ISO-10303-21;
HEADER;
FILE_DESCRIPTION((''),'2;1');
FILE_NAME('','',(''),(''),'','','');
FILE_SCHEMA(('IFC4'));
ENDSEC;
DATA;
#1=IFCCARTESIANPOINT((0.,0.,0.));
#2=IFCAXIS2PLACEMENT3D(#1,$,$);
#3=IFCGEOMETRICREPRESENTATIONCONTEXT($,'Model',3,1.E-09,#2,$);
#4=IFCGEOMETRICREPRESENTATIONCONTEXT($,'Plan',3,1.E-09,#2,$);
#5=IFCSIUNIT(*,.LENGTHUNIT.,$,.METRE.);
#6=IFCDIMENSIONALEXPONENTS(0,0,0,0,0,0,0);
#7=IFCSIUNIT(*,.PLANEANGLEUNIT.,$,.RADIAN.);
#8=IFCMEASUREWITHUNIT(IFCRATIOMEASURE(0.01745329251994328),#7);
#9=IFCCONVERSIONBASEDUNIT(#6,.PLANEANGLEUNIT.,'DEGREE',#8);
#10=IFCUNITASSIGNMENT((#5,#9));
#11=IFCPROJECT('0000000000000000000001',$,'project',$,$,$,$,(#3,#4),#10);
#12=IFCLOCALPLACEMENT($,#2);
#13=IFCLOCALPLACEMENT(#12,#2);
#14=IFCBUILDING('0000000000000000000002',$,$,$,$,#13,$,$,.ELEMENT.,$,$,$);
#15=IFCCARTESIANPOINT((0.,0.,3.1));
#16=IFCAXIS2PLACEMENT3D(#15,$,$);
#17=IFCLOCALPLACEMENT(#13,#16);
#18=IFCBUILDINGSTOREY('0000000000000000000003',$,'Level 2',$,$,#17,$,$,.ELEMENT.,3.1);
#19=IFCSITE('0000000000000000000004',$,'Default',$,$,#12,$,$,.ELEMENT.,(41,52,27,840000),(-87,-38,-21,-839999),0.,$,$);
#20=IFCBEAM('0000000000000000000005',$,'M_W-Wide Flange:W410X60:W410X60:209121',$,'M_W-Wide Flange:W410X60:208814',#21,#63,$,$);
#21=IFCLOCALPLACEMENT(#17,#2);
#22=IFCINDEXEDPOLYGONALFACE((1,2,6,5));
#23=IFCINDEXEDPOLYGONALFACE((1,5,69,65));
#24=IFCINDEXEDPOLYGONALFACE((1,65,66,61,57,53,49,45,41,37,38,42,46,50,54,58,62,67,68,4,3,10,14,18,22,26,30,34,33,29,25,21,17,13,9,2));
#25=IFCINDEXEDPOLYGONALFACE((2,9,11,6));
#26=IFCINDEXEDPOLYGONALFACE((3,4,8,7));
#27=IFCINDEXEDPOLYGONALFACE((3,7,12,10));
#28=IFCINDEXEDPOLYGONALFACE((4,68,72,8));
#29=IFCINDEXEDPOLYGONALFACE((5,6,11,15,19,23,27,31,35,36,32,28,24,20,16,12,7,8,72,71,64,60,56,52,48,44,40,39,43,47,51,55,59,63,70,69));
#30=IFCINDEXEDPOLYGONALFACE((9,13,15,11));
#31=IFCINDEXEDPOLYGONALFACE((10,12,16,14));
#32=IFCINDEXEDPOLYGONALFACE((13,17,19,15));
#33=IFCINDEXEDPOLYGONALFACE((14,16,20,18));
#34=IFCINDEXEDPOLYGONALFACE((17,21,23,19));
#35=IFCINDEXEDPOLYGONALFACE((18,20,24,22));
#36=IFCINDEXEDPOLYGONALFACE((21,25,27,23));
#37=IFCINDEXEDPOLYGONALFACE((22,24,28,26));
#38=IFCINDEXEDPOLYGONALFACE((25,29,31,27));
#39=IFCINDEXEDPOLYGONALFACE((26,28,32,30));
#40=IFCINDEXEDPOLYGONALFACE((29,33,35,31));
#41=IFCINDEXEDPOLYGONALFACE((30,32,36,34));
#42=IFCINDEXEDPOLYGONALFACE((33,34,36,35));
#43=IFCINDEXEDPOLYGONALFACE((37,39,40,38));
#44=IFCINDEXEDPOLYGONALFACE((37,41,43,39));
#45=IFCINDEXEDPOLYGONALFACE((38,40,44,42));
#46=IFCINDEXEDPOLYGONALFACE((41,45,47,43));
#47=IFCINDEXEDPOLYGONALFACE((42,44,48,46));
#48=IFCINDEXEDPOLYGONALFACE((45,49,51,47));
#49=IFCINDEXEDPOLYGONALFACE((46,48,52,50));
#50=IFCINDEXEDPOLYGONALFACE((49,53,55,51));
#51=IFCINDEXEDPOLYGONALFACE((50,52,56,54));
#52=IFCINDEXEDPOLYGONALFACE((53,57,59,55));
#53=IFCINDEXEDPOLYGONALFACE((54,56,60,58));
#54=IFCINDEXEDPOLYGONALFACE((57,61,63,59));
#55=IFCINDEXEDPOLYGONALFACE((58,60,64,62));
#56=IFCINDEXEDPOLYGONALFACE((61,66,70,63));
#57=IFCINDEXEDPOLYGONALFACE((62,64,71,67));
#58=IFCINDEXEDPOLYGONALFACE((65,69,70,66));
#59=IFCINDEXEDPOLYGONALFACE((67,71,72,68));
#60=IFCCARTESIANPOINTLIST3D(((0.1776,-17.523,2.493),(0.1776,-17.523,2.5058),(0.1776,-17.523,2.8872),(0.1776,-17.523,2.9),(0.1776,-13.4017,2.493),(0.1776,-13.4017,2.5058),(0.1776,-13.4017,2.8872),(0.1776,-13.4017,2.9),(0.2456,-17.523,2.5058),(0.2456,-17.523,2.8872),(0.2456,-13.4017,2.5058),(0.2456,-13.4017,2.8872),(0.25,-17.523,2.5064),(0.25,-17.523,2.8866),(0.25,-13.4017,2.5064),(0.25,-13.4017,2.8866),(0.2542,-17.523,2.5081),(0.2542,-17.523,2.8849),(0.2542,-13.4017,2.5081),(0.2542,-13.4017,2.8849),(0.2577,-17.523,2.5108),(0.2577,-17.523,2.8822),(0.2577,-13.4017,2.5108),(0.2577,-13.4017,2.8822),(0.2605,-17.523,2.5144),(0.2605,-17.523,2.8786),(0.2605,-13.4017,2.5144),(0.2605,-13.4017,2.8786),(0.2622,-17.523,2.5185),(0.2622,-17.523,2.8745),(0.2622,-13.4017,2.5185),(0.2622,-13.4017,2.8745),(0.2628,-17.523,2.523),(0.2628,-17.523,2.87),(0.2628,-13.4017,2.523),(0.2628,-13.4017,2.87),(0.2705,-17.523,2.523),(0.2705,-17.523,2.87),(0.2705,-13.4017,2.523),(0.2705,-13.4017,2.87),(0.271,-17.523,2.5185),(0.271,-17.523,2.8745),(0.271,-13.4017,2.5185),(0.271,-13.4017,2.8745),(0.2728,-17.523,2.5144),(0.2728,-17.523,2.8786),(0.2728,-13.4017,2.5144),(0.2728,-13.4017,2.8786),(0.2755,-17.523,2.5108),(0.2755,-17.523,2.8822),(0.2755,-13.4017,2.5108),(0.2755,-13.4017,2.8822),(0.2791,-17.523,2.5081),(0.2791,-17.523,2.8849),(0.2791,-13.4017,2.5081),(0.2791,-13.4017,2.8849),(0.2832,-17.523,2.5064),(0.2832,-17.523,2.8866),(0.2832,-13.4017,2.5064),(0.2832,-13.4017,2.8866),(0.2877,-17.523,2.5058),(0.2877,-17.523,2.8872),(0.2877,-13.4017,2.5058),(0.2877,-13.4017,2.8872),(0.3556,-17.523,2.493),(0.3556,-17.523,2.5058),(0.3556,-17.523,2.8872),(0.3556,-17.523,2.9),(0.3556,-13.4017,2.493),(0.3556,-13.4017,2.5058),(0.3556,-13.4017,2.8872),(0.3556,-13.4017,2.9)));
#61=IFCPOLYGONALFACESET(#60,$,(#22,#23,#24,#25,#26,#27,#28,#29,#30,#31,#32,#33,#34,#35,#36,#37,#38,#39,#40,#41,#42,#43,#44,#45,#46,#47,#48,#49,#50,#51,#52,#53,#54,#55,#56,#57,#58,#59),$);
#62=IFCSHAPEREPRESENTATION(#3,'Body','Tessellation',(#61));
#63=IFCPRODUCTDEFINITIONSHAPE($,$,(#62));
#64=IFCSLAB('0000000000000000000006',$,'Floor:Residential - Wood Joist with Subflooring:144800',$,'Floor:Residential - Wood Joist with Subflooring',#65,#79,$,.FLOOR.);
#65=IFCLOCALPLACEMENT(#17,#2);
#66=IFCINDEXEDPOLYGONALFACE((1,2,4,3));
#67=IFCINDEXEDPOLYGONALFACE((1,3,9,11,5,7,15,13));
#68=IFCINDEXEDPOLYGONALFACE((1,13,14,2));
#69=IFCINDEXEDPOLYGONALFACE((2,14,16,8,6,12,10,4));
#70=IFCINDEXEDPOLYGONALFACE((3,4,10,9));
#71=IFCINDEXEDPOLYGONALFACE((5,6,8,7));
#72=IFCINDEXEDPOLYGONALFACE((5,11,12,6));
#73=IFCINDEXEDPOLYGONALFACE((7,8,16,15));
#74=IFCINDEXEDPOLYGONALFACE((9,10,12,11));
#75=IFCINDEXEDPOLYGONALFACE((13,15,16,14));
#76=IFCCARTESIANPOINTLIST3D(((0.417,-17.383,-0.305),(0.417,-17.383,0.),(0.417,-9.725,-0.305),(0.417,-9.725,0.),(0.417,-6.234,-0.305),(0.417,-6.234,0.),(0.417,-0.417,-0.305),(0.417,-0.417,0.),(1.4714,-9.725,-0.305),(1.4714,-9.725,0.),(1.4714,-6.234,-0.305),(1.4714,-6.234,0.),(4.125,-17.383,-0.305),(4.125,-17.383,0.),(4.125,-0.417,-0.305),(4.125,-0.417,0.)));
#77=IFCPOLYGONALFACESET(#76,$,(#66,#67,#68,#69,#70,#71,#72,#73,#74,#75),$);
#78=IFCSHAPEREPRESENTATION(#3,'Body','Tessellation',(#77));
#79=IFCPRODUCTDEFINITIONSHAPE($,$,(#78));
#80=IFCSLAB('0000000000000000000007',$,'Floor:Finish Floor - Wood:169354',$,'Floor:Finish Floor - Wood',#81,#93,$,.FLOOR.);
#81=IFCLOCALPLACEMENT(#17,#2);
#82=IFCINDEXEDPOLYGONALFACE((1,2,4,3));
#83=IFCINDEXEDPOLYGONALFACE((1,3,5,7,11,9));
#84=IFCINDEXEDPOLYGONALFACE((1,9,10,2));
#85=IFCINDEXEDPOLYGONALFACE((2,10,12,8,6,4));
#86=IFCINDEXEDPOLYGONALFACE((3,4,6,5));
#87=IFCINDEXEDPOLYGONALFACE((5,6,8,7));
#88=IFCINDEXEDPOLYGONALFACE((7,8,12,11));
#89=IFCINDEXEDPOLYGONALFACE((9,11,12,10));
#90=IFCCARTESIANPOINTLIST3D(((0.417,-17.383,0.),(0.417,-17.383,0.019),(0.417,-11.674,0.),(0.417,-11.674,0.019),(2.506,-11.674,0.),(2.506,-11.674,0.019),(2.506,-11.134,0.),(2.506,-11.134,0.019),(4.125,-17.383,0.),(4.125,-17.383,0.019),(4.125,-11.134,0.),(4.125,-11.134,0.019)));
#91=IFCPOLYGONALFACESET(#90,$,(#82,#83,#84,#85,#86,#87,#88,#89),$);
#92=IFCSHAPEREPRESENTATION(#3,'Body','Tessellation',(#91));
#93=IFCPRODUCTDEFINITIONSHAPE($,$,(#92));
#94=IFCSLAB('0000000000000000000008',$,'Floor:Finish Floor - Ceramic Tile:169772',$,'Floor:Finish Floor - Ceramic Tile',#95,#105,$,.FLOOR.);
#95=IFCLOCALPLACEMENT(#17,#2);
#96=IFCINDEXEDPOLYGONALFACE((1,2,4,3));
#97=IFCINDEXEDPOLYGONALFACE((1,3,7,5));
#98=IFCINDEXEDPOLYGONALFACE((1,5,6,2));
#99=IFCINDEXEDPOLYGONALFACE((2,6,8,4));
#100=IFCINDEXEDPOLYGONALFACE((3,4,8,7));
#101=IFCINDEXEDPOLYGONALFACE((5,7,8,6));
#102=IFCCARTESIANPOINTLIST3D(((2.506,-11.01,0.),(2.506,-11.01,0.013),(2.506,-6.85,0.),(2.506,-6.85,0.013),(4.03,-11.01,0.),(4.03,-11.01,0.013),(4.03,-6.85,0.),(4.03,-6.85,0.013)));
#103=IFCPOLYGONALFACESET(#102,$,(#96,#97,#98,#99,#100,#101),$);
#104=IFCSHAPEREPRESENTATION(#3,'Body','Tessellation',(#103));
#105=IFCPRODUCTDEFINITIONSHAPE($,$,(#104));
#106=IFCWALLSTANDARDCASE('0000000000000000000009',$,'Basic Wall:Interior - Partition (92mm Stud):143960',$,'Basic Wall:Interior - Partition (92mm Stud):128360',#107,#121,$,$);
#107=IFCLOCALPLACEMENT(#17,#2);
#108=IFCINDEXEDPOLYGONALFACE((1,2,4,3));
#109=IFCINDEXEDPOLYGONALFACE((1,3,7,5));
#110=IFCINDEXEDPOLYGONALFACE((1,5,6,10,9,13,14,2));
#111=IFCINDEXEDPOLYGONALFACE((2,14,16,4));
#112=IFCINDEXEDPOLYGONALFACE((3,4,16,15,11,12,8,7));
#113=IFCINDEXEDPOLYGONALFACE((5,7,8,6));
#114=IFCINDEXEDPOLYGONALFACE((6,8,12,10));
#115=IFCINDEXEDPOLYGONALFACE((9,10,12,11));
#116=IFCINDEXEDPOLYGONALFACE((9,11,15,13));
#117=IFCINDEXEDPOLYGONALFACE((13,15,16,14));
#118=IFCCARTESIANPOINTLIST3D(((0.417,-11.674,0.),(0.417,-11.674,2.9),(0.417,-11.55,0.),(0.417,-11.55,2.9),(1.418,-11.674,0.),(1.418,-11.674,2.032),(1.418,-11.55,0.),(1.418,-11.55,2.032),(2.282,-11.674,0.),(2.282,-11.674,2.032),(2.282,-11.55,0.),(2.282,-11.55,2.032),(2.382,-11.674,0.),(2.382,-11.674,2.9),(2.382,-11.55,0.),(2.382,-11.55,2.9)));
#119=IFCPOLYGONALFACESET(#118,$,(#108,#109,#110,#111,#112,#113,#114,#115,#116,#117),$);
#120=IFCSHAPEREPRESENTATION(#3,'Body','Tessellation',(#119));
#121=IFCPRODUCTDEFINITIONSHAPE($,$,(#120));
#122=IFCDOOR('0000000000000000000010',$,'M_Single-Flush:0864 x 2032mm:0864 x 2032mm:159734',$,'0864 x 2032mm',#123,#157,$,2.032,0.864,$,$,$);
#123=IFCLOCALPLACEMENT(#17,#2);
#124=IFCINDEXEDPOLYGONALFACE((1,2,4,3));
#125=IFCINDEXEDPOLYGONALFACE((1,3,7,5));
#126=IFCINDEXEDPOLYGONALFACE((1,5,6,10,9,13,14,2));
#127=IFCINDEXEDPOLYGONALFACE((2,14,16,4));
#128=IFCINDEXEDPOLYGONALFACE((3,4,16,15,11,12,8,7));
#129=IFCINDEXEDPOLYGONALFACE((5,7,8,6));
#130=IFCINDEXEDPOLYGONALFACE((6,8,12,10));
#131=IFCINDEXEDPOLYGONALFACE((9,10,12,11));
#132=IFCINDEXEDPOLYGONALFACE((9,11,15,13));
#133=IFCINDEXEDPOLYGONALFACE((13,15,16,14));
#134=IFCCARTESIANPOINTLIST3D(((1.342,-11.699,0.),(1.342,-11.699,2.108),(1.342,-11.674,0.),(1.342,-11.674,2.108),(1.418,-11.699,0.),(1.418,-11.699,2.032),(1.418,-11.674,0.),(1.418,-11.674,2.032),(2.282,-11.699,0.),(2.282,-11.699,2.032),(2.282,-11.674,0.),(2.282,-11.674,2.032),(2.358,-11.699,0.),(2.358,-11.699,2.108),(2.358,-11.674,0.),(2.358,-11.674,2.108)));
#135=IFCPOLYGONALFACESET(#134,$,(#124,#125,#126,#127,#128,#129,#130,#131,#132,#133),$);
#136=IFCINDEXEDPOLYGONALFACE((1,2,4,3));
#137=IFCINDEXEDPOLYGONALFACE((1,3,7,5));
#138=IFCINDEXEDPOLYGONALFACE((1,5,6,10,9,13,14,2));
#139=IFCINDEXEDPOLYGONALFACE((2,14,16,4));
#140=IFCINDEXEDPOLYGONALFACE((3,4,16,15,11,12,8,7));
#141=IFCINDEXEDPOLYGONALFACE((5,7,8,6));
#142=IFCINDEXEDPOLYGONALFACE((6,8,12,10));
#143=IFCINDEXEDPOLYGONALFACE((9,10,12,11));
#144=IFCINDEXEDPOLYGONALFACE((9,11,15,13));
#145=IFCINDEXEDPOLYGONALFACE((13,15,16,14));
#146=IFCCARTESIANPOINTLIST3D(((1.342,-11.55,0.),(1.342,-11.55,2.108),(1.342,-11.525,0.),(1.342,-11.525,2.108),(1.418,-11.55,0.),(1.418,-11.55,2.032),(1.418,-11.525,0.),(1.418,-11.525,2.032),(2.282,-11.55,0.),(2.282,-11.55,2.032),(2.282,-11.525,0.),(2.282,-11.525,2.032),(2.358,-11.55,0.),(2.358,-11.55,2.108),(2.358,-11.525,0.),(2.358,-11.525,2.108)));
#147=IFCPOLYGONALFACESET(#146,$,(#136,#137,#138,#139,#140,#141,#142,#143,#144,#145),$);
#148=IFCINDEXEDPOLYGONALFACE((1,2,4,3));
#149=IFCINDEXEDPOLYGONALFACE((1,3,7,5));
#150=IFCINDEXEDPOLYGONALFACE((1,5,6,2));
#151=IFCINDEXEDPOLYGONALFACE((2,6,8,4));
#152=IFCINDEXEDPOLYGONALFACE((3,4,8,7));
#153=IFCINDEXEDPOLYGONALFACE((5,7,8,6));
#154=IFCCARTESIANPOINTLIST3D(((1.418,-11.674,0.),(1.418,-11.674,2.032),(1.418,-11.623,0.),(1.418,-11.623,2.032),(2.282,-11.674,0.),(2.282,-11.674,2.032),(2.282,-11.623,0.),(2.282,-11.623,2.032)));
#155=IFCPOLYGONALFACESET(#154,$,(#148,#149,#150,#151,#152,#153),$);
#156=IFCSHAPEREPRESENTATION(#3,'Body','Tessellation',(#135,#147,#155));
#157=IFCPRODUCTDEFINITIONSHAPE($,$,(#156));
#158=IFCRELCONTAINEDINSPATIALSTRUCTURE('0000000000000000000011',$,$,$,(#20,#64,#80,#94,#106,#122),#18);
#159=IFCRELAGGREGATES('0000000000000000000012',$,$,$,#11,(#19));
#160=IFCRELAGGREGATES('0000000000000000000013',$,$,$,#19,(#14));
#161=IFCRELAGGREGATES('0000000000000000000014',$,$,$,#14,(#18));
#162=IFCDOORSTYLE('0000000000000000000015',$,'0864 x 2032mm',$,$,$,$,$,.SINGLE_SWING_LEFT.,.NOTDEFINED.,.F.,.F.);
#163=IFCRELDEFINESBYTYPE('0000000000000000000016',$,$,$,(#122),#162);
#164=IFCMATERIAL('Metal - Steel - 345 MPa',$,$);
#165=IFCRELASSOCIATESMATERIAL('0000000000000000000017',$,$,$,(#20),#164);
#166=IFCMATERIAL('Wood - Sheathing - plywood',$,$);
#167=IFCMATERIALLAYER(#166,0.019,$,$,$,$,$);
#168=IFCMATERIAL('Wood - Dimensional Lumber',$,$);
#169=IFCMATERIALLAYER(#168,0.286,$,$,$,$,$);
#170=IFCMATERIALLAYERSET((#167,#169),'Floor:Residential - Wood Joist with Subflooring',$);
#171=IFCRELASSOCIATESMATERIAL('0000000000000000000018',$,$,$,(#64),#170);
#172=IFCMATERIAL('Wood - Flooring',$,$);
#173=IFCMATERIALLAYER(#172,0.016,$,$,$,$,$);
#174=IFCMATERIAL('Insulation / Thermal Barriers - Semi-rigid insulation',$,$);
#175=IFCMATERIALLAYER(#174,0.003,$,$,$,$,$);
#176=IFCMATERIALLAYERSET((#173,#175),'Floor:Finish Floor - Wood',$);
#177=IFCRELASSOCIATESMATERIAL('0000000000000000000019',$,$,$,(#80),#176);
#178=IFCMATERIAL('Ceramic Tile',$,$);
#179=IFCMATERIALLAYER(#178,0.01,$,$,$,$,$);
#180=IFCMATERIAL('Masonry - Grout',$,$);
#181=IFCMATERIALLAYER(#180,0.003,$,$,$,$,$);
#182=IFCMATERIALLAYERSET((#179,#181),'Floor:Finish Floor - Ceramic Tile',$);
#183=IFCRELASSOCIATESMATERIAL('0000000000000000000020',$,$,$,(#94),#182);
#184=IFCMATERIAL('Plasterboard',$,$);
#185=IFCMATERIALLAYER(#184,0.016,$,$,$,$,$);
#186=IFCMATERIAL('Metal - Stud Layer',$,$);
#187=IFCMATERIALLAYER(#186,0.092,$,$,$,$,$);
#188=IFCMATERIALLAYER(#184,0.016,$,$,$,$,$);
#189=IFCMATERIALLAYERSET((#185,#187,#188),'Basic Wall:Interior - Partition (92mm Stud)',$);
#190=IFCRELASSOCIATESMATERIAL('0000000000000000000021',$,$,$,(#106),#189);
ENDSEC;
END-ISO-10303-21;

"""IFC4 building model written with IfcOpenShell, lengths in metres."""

from ifc_helpers import new_model, entity, si_unit, converted_unit, frame, frame_2d, origin, origin_2d_with_axis, place, context, project, spatial, polyline, circle_curve, parameter, trimmed, segment, composite_curve, rectangle, outline, extrude, source, transform, mapped, material, layer, layer_set, layer_usage, type_object, type_shapes, element, fill, save


model = new_model("IFC4")

# Units and contexts
model_context = context("Model", 3, precision=1e-09, world=origin())
plan_context = context("Plan", 3, precision=1e-09, world=origin())
ifc_project = project(units=[si_unit("LENGTHUNIT", "METRE"), converted_unit("PLANEANGLEUNIT", "DEGREE", entity("IfcRatioMeasure", 0.01745329251994328), si_unit("PLANEANGLEUNIT", "RADIAN"), dimensions=[0, 0, 0, 0, 0, 0, 0])], contexts=[model_context, plan_context])

# Site, building, storey
site_placement = place(None, origin())
site = spatial("IfcSite", under=ifc_project, at=site_placement, Name="Default", CompositionType="ELEMENT", RefLatitude=(41, 52, 27, 840000), RefLongitude=(-87, -38, -21, -839999), RefElevation=0.0)
building_placement = place(site_placement, origin())
building = spatial("IfcBuilding", under=site, at=building_placement, CompositionType="ELEMENT")
storey_placement = place(building_placement, frame((0.0, 0.0, 3.1)))
storey = spatial("IfcBuildingStorey", under=building, at=storey_placement, Name="Level 2", CompositionType="ELEMENT", Elevation=3.1)

# Beam
ifc_material_1 = material(Name="Metal - Steel - 345 MPa")
beam_placement = place(storey_placement, frame((0.2666, -13.4017, 2.9), z_axis=(0.0, 0.0, 1.0), x_axis=(-1.0, 0.0, 0.0)))
element("IfcBeam", 1, at=beam_placement, inside=storey, material=ifc_material_1, Name="M_W-Wide Flange:W410X60:W410X60:209121", ObjectType="M_W-Wide Flange:W410X60:208814", context=model_context, shape_type="SweptSolid", body=[
    extrude(outline(composite_curve([segment(polyline([(0.1907, -0.089), (0.2035, -0.089)]), True, "CONTINUOUS"), segment(polyline([(0.2035, -0.089), (0.2035, 0.089)]), True, "CONTINUOUS"), segment(polyline([(0.2035, 0.089), (0.1907, 0.089)]), True, "CONTINUOUS"), segment(polyline([(0.1907, 0.089), (0.1907, 0.021)]), True, "CONTINUOUS"), segment(trimmed(circle_curve(frame_2d((0.1735, 0.021), x_axis=(1.0, 0.0)), 0.0172), [parameter(270.0)], [parameter(360.0)], True, "PARAMETER"), False, "CONTINUOUS"), segment(polyline([(0.1735, 0.0038), (-0.1735, 0.0038)]), True, "CONTINUOUS"), segment(trimmed(circle_curve(frame_2d((-0.1735, 0.021), x_axis=(0.0, -1.0)), 0.0172), [parameter(270.0)], [parameter(360.0)], True, "PARAMETER"), False, "CONTINUOUS"), segment(polyline([(-0.1907, 0.021), (-0.1907, 0.089)]), True, "CONTINUOUS"), segment(polyline([(-0.1907, 0.089), (-0.2035, 0.089)]), True, "CONTINUOUS"), segment(polyline([(-0.2035, 0.089), (-0.2035, -0.089)]), True, "CONTINUOUS"), segment(polyline([(-0.2035, -0.089), (-0.1907, -0.089)]), True, "CONTINUOUS"), segment(polyline([(-0.1907, -0.089), (-0.1907, -0.0211)]), True, "CONTINUOUS"), segment(trimmed(circle_curve(frame_2d((-0.1735, -0.0211), x_axis=(-1.0, 0.0)), 0.0172), [parameter(270.0)], [parameter(0.0)], True, "PARAMETER"), False, "CONTINUOUS"), segment(polyline([(-0.1735, -0.0039), (0.1735, -0.0039)]), True, "CONTINUOUS"), segment(trimmed(circle_curve(frame_2d((0.1735, -0.0211), x_axis=(0.0, 1.0)), 0.0172), [parameter(270.0)], [parameter(0.0)], True, "PARAMETER"), False, "CONTINUOUS"), segment(polyline([(0.1907, -0.0211), (0.1907, -0.089)]), True, "CONTINUOUS")], self_intersect=False)), frame((0.0, 4.1213, -0.2035), z_axis=(0.0, -1.0, 0.0), x_axis=(0.0, 0.0, -1.0)), (0.0, 0.0, 1.0), 4.1213),
])

# Slabs
ifc_material_2 = material(Name="Wood - Sheathing - plywood")
ifc_layer_1 = layer(ifc_material_2, 0.019)
ifc_material_3 = material(Name="Wood - Dimensional Lumber")
ifc_layer_2 = layer(ifc_material_3, 0.286)
ifc_layer_set_1 = layer_set([ifc_layer_1, ifc_layer_2], Name="Floor:Residential - Wood Joist with Subflooring")
ifc_layer_usage_1 = layer_usage(ifc_layer_set_1, "AXIS3", "POSITIVE", 0.0)
slab_1_placement = place(storey_placement, frame((0.417, -17.383, -0.305)))
element("IfcSlab", 2, at=slab_1_placement, inside=storey, material=ifc_layer_usage_1, Name="Floor:Residential - Wood Joist with Subflooring:144800", ObjectType="Floor:Residential - Wood Joist with Subflooring", PredefinedType="FLOOR", context=model_context, shape_type="SweptSolid", body=[
    extrude(outline(polyline([(-1.854, 8.483), (-1.854, -8.483), (1.854, -8.483), (1.854, -0.825), (0.7996, -0.825), (0.7996, 2.666), (1.854, 2.666), (1.854, 8.483), (-1.854, 8.483)])), frame((1.854, 8.483, 0.305), z_axis=(0.0, 0.0, -1.0), x_axis=(-1.0, 0.0, 0.0)), (0.0, 0.0, 1.0), 0.305),
])
ifc_material_4 = material(Name="Wood - Flooring")
ifc_layer_3 = layer(ifc_material_4, 0.016)
ifc_material_5 = material(Name="Insulation / Thermal Barriers - Semi-rigid insulation")
ifc_layer_4 = layer(ifc_material_5, 0.003)
ifc_layer_set_2 = layer_set([ifc_layer_3, ifc_layer_4], Name="Floor:Finish Floor - Wood")
ifc_layer_usage_2 = layer_usage(ifc_layer_set_2, "AXIS3", "POSITIVE", 0.0)
slab_2_placement = place(storey_placement, frame((0.417, -17.383, 0.0)))
element("IfcSlab", 3, at=slab_2_placement, inside=storey, material=ifc_layer_usage_2, Name="Floor:Finish Floor - Wood:169354", ObjectType="Floor:Finish Floor - Wood", PredefinedType="FLOOR", context=model_context, shape_type="SweptSolid", body=[
    extrude(outline(polyline([(-1.854, -3.1245), (1.854, -3.1245), (1.854, 2.5845), (-0.235, 2.5845), (-0.235, 3.1245), (-1.854, 3.1245), (-1.854, -3.1245)])), frame((1.854, 3.1245, 0.019), z_axis=(0.0, 0.0, -1.0), x_axis=(-1.0, 0.0, 0.0)), (0.0, 0.0, 1.0), 0.019),
])
ifc_material_6 = material(Name="Ceramic Tile")
ifc_layer_5 = layer(ifc_material_6, 0.01)
ifc_material_7 = material(Name="Masonry - Grout")
ifc_layer_6 = layer(ifc_material_7, 0.003)
ifc_layer_set_3 = layer_set([ifc_layer_5, ifc_layer_6], Name="Floor:Finish Floor - Ceramic Tile")
ifc_layer_usage_3 = layer_usage(ifc_layer_set_3, "AXIS3", "POSITIVE", 0.0)
slab_3_placement = place(storey_placement, frame((2.506, -11.01, 0.0)))
element("IfcSlab", 4, at=slab_3_placement, inside=storey, material=ifc_layer_usage_3, Name="Floor:Finish Floor - Ceramic Tile:169772", ObjectType="Floor:Finish Floor - Ceramic Tile", PredefinedType="FLOOR", context=model_context, shape_type="SweptSolid", body=[
    extrude(rectangle(XDim=4.16, YDim=1.524, at=frame_2d((0.0, 0.0), x_axis=(0.0, -1.0))), frame((0.762, 2.08, 0.013), z_axis=(0.0, 0.0, -1.0), x_axis=(-1.0, 0.0, 0.0)), (0.0, 0.0, 1.0), 0.013),
])

# Shared definitions
ifc_material_8 = material(Name="Metal - Stud Layer")
ifc_material_9 = material(Name="Plasterboard")

# Wall, opening, door
ifc_layer_7 = layer(ifc_material_9, 0.016)
ifc_layer_8 = layer(ifc_material_8, 0.092)
ifc_layer_9 = layer(ifc_material_9, 0.016)
ifc_layer_set_4 = layer_set([ifc_layer_7, ifc_layer_8, ifc_layer_9], Name="Basic Wall:Interior - Partition (92mm Stud)")
ifc_layer_usage_4 = layer_usage(ifc_layer_set_4, "AXIS2", "NEGATIVE", 0.062)
wall_1_placement = place(storey_placement, frame((2.382, -11.612, 0.0), z_axis=(0.0, 0.0, 1.0), x_axis=(-1.0, 0.0, 0.0)))
wall_1 = element("IfcWallStandardCase", 5, at=wall_1_placement, inside=storey, material=ifc_layer_usage_4, Name="Basic Wall:Interior - Partition (92mm Stud):143960", ObjectType="Basic Wall:Interior - Partition (92mm Stud):128360", context=model_context, shape_type="SweptSolid", body=[
    extrude(rectangle(XDim=1.965, YDim=0.124, at=frame_2d((0.9825, 0.0), x_axis=(-1.0, 0.0))), origin(), (0.0, 0.0, 1.0), 2.9),
])
opening_1_placement = place(wall_1_placement, frame((0.1, -0.062, 0.0)))
opening_1 = element("IfcOpeningElement", 6, at=opening_1_placement, cuts=wall_1, ObjectType="Opening", context=model_context, shape_type="SweptSolid", body=[
    extrude(rectangle(XDim=0.864, YDim=2.032, at=frame_2d((1.016, 0.432), x_axis=(0.0, -1.0))), frame((0.0, 0.0, 0.0), z_axis=(0.0, 1.0, 0.0), x_axis=(0.0, 0.0, 1.0)), (0.0, 0.0, 1.0), 0.124),
])
door_style = type_object("IfcDoorStyle", Name="0864 x 2032mm", ConstructionType="NOTDEFINED", OperationType="SINGLE_SWING_LEFT", ParameterTakesPrecedence=False, Sizeable=False)
shared_shape_1 = source(origin(), model_context, "Body", "SweptSolid", [
    extrude(outline(polyline([(-0.508, -1.073), (0.508, -1.073), (0.508, 1.035), (0.432, 1.035), (0.432, -0.997), (-0.432, -0.997), (-0.432, 1.035), (-0.508, 1.035), (-0.508, -1.073)])), frame((0.432, 0.149, 1.035), z_axis=(0.0, -1.0, 0.0), x_axis=(-1.0, 0.0, 0.0)), (0.0, 0.0, 1.0), 0.025),
    extrude(outline(polyline([(-1.073, -0.508), (1.035, -0.508), (1.035, -0.432), (-0.997, -0.432), (-0.997, 0.432), (1.035, 0.432), (1.035, 0.508), (-1.073, 0.508), (-1.073, -0.508)])), frame((0.432, 0.0, 1.035), z_axis=(0.0, -1.0, 0.0), x_axis=(0.0, 0.0, -1.0)), (0.0, 0.0, 1.0), 0.025),
    extrude(rectangle(XDim=0.864, YDim=0.051, at=origin_2d_with_axis()), frame((0.432, 0.0985, 0.0)), (0.0, 0.0, 1.0), 2.032),
])
type_shapes(door_style, [shared_shape_1])
door_placement = place(opening_1_placement, origin())
door = element("IfcDoor", 7, at=door_placement, inside=storey, type_object=door_style, Name="M_Single-Flush:0864 x 2032mm:0864 x 2032mm:159734", ObjectType="0864 x 2032mm", OverallHeight=2.032, OverallWidth=0.864, context=model_context, shape_type="MappedRepresentation", body=[
    mapped(shared_shape_1, transform((0.0, 0.0, 0.0), scale=1.0)),
])
fill(opening_1, door)

save(model, "model.ifc")
